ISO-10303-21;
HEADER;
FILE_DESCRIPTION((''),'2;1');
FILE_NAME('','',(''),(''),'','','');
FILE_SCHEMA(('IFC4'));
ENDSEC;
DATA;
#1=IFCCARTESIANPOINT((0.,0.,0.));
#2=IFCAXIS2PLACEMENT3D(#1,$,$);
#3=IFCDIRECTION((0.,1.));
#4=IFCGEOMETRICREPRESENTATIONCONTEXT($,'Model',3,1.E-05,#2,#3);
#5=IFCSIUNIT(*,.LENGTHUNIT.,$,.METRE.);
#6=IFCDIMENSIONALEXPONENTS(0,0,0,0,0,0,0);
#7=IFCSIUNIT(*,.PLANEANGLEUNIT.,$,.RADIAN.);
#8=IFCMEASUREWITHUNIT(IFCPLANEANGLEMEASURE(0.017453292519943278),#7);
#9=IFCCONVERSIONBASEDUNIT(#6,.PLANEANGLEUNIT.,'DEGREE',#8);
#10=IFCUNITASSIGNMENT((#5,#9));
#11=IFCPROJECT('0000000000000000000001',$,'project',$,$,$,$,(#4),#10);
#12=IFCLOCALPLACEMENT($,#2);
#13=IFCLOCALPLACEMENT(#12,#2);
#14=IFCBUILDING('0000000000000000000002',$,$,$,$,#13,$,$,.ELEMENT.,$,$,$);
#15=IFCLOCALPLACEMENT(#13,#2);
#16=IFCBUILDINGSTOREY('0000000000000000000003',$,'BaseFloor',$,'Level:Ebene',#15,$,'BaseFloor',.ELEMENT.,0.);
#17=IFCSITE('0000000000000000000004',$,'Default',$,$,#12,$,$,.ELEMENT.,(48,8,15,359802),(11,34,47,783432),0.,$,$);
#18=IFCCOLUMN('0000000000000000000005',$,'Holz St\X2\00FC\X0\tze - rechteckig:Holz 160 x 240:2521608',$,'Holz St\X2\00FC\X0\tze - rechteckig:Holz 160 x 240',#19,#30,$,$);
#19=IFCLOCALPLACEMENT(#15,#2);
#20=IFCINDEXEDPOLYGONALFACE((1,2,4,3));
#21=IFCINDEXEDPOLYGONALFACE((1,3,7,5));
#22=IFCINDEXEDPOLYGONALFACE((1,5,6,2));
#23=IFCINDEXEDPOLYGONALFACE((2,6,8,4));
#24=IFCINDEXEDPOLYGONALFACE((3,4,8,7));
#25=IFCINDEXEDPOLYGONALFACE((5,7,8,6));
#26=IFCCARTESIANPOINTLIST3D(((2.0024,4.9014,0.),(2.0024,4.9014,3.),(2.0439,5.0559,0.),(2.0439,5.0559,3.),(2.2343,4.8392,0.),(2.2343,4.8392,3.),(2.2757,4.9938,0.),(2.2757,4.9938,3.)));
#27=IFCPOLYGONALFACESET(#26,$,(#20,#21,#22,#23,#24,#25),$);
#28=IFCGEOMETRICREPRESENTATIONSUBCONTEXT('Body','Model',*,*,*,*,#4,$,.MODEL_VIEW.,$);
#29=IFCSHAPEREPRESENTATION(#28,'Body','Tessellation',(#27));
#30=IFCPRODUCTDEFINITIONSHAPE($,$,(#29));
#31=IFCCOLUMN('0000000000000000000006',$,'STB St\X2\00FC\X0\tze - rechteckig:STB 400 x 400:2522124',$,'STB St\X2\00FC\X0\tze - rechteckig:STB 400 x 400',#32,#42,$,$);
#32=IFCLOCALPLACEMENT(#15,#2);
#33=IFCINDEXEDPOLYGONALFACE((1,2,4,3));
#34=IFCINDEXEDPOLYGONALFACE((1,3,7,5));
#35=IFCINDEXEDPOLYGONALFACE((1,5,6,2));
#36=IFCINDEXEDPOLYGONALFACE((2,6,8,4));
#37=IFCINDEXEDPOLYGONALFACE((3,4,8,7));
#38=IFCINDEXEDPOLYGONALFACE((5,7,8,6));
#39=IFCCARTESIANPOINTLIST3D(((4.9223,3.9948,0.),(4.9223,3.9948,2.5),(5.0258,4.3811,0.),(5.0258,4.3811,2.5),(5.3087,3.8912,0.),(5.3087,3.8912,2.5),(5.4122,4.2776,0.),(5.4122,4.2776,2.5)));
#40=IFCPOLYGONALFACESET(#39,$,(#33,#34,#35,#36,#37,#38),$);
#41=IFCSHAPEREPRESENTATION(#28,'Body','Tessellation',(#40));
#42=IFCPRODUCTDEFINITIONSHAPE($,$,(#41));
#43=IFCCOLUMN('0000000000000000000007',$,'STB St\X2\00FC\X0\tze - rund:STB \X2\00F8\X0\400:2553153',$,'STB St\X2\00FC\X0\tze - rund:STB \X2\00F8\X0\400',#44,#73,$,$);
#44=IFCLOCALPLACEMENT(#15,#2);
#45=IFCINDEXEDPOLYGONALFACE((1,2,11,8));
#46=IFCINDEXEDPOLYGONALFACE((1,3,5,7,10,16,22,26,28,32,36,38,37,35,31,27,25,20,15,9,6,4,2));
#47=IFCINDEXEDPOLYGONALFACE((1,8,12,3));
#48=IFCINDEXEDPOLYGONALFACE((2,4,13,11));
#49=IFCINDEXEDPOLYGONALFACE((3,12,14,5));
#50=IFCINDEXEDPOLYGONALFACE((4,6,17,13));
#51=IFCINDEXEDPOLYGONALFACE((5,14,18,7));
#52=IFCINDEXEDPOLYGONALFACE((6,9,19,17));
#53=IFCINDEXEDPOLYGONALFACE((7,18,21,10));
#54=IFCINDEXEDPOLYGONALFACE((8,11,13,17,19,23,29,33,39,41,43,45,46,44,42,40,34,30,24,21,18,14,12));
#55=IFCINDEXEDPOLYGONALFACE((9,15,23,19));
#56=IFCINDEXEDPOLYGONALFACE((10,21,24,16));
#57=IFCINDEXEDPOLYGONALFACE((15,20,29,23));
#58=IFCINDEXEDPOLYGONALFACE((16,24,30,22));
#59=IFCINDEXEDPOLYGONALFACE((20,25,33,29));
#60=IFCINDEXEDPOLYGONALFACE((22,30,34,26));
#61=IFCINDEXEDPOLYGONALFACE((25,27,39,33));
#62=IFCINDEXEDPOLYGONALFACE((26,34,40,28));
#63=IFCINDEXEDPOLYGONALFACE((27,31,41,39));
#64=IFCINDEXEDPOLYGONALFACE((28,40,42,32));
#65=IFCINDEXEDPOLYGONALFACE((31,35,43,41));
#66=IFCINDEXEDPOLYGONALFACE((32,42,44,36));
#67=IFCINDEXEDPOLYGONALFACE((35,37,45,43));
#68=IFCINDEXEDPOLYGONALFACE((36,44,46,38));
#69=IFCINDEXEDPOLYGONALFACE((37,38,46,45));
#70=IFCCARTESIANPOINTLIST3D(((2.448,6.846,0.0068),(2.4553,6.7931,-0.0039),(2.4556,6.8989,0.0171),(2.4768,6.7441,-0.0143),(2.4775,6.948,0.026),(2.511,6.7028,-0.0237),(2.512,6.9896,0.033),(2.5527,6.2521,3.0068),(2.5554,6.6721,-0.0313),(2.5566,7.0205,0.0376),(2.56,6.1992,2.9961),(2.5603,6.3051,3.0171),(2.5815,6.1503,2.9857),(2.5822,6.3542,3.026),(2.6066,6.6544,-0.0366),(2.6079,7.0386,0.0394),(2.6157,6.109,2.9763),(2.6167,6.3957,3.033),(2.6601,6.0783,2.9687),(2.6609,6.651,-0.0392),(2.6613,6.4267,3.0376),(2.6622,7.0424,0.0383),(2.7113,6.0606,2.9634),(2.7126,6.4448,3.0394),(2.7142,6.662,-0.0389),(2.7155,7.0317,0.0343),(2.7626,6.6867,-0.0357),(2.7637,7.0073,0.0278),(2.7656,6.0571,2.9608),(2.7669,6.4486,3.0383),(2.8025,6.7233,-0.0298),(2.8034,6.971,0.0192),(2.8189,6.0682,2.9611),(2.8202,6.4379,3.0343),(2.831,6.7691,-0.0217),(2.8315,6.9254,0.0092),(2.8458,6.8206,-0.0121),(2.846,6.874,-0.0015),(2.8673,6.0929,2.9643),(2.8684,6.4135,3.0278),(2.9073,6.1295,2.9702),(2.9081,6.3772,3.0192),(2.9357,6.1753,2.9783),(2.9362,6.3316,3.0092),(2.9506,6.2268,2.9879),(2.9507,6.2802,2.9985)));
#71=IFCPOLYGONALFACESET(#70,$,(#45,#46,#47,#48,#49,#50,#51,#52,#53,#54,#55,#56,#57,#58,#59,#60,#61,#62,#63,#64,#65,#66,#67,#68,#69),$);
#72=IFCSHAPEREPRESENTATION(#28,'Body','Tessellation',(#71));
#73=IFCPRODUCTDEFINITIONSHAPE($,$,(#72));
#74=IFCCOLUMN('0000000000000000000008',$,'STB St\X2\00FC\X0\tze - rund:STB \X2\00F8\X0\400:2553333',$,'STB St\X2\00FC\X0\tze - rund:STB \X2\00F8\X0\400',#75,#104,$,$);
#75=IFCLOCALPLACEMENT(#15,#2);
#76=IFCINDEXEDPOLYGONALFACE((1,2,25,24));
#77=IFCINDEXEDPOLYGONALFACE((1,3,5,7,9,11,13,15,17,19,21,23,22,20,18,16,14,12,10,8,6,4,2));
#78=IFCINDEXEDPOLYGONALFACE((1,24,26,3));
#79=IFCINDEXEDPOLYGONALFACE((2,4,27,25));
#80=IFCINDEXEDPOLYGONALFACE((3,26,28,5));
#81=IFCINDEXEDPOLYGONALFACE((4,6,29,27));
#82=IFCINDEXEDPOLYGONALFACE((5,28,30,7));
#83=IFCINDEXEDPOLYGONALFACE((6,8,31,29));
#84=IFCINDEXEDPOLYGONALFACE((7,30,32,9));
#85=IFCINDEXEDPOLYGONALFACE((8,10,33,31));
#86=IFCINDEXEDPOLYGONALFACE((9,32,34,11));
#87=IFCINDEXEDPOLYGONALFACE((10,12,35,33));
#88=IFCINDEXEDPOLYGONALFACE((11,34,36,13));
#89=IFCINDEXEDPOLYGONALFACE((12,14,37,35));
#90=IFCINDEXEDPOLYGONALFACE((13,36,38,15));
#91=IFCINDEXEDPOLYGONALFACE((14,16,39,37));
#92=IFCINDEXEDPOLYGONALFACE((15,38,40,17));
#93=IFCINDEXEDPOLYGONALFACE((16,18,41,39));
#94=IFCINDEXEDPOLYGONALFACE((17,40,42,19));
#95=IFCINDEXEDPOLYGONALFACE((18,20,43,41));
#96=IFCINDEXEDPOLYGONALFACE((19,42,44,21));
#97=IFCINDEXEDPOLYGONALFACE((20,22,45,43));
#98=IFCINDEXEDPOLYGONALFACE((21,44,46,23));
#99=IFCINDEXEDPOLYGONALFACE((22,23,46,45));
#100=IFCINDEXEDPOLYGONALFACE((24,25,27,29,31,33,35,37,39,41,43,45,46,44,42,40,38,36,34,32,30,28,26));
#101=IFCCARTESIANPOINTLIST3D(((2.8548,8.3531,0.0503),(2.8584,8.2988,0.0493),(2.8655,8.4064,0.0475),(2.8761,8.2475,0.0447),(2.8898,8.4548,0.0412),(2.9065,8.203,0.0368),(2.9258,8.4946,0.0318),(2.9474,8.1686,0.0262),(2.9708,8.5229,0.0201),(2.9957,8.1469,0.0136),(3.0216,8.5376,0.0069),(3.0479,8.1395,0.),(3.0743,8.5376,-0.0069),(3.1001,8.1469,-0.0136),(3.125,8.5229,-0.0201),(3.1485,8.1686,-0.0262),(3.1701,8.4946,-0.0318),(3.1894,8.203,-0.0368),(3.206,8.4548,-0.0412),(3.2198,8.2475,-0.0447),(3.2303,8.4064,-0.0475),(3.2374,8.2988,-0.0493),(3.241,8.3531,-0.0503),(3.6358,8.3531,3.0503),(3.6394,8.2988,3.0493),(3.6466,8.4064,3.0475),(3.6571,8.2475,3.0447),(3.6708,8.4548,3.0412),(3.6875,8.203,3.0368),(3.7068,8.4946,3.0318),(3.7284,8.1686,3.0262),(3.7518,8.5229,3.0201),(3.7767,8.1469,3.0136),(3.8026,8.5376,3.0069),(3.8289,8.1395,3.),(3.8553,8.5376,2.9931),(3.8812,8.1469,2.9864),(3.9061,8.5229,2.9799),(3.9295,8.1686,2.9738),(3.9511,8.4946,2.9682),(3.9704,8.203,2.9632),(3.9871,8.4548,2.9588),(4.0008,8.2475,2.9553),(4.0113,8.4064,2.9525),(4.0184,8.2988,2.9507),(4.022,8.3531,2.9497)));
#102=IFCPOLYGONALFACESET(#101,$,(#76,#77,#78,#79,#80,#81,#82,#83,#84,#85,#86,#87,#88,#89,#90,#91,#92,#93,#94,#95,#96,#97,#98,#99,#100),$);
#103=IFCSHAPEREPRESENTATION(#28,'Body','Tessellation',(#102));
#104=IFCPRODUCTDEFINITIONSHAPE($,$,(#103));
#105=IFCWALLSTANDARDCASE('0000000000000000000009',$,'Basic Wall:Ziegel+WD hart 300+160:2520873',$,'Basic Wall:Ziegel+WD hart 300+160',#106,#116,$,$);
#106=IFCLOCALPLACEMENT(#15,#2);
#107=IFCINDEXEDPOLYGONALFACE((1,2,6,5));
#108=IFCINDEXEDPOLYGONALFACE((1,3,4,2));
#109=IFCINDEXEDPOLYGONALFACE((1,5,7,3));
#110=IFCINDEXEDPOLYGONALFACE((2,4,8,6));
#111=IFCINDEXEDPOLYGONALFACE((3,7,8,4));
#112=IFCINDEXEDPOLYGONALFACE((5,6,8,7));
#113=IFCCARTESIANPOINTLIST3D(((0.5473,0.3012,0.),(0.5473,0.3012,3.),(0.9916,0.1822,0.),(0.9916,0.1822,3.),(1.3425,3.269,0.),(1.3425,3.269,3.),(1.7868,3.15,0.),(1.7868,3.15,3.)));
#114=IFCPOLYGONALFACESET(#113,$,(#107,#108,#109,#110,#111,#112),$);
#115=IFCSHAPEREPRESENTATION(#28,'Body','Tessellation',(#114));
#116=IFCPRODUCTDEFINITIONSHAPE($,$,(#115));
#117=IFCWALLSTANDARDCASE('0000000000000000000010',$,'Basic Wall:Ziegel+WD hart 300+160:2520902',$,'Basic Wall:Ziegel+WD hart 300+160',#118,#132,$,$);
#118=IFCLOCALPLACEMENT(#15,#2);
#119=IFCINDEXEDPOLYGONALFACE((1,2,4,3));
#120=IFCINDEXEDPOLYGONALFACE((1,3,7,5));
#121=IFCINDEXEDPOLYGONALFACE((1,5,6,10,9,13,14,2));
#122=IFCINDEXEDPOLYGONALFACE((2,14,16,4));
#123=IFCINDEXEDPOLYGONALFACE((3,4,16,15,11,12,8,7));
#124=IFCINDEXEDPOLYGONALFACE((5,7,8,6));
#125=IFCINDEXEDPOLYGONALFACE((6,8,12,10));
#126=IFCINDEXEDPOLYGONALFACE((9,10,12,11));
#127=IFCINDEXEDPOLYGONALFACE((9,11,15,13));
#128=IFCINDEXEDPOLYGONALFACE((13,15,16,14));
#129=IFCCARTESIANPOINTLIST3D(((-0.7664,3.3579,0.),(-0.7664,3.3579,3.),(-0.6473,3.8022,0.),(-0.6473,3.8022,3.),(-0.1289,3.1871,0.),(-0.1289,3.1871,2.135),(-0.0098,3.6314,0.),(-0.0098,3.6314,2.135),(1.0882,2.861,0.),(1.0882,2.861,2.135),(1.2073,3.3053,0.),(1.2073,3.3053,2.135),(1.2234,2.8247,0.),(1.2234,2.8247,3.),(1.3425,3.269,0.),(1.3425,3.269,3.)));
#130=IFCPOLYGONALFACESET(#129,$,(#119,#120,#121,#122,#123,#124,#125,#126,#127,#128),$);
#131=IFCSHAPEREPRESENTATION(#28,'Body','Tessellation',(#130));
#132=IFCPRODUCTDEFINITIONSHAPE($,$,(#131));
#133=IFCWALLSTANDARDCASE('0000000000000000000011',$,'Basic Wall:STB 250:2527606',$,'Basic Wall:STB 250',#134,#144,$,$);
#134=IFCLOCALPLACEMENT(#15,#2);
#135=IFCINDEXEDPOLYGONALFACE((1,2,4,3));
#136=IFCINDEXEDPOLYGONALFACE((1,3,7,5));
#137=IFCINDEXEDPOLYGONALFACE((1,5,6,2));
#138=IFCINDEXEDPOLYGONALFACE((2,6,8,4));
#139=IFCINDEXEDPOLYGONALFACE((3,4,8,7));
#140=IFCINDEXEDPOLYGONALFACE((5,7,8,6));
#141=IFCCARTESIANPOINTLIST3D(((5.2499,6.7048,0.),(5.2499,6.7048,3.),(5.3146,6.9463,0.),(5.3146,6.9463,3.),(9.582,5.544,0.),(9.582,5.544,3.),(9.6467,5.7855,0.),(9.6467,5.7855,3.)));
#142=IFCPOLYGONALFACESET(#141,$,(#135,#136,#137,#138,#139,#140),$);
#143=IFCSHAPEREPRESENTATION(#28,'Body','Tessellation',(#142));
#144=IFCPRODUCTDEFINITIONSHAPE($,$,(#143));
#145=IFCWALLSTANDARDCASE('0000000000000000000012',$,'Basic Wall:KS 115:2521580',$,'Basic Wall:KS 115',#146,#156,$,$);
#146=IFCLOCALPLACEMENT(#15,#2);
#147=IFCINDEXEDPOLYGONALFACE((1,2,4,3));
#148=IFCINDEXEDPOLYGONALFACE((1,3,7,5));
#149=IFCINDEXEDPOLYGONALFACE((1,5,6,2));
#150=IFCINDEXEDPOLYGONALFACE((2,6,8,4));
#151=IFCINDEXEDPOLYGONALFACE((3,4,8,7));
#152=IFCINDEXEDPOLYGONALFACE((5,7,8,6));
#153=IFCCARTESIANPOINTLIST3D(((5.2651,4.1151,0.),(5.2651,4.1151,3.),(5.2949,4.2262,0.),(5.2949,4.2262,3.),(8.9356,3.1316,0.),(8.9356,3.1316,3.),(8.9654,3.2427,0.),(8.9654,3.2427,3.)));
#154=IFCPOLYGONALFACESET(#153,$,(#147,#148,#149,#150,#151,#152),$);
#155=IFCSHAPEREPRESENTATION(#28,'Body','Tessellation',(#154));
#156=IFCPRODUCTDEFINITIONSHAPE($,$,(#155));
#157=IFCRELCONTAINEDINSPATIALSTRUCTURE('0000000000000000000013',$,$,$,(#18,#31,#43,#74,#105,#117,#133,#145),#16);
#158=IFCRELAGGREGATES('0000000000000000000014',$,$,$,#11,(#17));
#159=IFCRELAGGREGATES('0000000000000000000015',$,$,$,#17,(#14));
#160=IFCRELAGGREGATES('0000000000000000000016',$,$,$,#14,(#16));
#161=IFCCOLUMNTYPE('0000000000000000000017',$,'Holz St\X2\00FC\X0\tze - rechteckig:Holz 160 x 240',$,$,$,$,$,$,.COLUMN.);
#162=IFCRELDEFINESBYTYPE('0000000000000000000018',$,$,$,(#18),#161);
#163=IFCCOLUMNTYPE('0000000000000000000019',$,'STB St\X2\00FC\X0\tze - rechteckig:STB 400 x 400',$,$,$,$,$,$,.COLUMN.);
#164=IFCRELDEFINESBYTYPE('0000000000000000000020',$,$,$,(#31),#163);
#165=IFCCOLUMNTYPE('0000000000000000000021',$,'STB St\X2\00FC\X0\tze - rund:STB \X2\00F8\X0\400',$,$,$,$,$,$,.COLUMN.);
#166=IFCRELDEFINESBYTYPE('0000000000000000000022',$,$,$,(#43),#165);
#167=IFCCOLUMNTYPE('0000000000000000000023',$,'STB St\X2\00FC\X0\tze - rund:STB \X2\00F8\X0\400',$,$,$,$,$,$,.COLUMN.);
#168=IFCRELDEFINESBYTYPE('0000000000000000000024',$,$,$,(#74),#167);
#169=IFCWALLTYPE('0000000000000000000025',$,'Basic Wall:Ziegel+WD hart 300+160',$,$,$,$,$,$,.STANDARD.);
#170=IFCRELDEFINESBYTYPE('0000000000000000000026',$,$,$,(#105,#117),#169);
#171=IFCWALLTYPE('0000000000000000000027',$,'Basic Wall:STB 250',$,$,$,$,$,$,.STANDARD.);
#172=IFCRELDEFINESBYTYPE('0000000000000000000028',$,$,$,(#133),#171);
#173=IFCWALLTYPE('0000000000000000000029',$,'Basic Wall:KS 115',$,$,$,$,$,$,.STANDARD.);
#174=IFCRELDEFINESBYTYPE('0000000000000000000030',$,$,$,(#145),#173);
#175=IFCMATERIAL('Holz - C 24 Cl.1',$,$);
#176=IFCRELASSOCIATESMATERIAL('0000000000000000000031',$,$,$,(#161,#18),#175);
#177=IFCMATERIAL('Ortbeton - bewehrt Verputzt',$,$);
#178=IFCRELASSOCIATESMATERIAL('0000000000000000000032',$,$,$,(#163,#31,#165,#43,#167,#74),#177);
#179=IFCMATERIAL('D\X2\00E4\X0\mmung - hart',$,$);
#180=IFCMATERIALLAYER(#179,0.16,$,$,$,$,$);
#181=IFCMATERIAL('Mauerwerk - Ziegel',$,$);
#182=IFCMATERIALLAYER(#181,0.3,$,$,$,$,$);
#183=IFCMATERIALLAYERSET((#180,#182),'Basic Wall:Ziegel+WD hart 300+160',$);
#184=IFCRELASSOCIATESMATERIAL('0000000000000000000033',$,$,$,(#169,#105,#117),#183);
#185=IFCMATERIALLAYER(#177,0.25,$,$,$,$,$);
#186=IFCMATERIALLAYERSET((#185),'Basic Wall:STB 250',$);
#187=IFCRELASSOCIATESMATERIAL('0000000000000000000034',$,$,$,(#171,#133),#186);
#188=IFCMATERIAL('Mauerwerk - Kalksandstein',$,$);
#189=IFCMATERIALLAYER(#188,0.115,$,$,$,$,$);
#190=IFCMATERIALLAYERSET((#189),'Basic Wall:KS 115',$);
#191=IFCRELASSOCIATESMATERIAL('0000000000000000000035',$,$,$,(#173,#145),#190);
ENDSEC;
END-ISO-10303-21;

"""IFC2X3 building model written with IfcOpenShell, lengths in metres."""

from ifc_helpers import new_model, entity, si_unit, converted_unit, direction, frame, frame_2d, origin, origin_2d_with_axis, place, context, subcontext, project, spatial, rectangle, circle, extrude, source, transform, mapped, material, layer, layer_set, layer_usage, type_object, type_shapes, element, save


model = new_model("IFC2X3")

# Units and contexts
model_context = context("Model", 3, precision=1e-05, world=origin(), true_north=direction((0.0, 1.0)))
body_context = subcontext(model_context, "Body", "Model", "MODEL_VIEW")
ifc_project = project(units=[si_unit("LENGTHUNIT", "METRE"), converted_unit("PLANEANGLEUNIT", "DEGREE", entity("IfcPlaneAngleMeasure", 0.017453292519943278), si_unit("PLANEANGLEUNIT", "RADIAN"), dimensions=[0, 0, 0, 0, 0, 0, 0])], contexts=[model_context])

# Site, building, storey
site_placement = place(None, origin())
site = spatial("IfcSite", under=ifc_project, at=site_placement, Name="Default", CompositionType="ELEMENT", RefLatitude=(48, 8, 15, 359802), RefLongitude=(11, 34, 47, 783432), RefElevation=0.0)
building_placement = place(site_placement, origin())
building = spatial("IfcBuilding", under=site, at=building_placement, CompositionType="ELEMENT")
storey_placement = place(building_placement, origin())
storey = spatial("IfcBuildingStorey", under=building, at=storey_placement, Name="BaseFloor", ObjectType="Level:Ebene", LongName="BaseFloor", CompositionType="ELEMENT", Elevation=0.0)

# Columns
ifc_material_1 = material(Name="Holz - C 24 Cl.1")
column_type_1 = type_object("IfcColumnType", Name="Holz Stütze - rechteckig:Holz 160 x 240", PredefinedType="COLUMN", material=ifc_material_1)
shared_shape_1 = source(origin(), body_context, "Body", "SweptSolid", [
    extrude(rectangle(XDim=0.16, YDim=0.24, at=frame_2d((0.0, 0.0), x_axis=(1.0, 0.0))), frame((2.1391, 4.9476, 0.0), z_axis=(0.0, 0.0, 1.0), x_axis=(-0.258819, -0.965926, 0.0)), (0.0, 0.0, 1.0), 3.0),
])
type_shapes(column_type_1, [shared_shape_1])
column_1_placement = place(storey_placement, origin())
element("IfcColumn", 1, at=column_1_placement, inside=storey, type_object=column_type_1, material=ifc_material_1, Name="Holz Stütze - rechteckig:Holz 160 x 240:2521608", ObjectType="Holz Stütze - rechteckig:Holz 160 x 240", context=body_context, shape_type="MappedRepresentation", body=[
    mapped(shared_shape_1, transform((0.0, 0.0, 0.0), scale=1.0)),
])
ifc_material_2 = material(Name="Ortbeton - bewehrt Verputzt")
column_type_2 = type_object("IfcColumnType", Name="STB Stütze - rechteckig:STB 400 x 400", PredefinedType="COLUMN", material=ifc_material_2)
shared_shape_2 = source(origin(), body_context, "Body", "SweptSolid", [
    extrude(rectangle(XDim=0.4, YDim=0.4, at=origin_2d_with_axis()), frame((0.0, 0.0, 0.0), z_axis=(0.0, 0.0, 1.0), x_axis=(-1.0, 0.0, 0.0)), (0.0, 0.0, 1.0), 2.5),
])
type_shapes(column_type_2, [shared_shape_2])
column_2_placement = place(storey_placement, frame((5.1672, 4.1362, 0.0), z_axis=(0.0, 0.0, 1.0), x_axis=(0.258819, 0.965926, 0.0)))
element("IfcColumn", 2, at=column_2_placement, inside=storey, type_object=column_type_2, material=ifc_material_2, Name="STB Stütze - rechteckig:STB 400 x 400:2522124", ObjectType="STB Stütze - rechteckig:STB 400 x 400", context=body_context, shape_type="MappedRepresentation", body=[
    mapped(shared_shape_2, transform((0.0, 0.0, 0.0), scale=1.0)),
])
column_type_3 = type_object("IfcColumnType", Name="STB Stütze - rund:STB ø400", PredefinedType="COLUMN", material=ifc_material_2)
shared_shape_3 = source(origin(), body_context, "Body", "SweptSolid", [
    extrude(circle(Radius=0.2, at=frame_2d((0.0, 0.0), x_axis=(1.0, 0.0))), frame((2.6479, 6.8466, 0.0), z_axis=(0.034218, -0.194063, 0.980392), x_axis=(-0.999409, -0.003353, 0.034218)), (0.0, 0.0, 1.0), 3.06),
])
type_shapes(column_type_3, [shared_shape_3])
column_3_placement = place(storey_placement, origin())
element("IfcColumn", 3, at=column_3_placement, inside=storey, type_object=column_type_3, material=ifc_material_2, Name="STB Stütze - rund:STB ø400:2553153", ObjectType="STB Stütze - rund:STB ø400", context=body_context, shape_type="MappedRepresentation", body=[
    mapped(shared_shape_3, transform((0.0, 0.0, 0.0), scale=1.0)),
])
column_type_4 = type_object("IfcColumnType", Name="STB Stütze - rund:STB ø400", PredefinedType="COLUMN", material=ifc_material_2)
shared_shape_4 = source(origin(), body_context, "Body", "SweptSolid", [
    extrude(circle(Radius=0.2, at=frame_2d((0.0, 0.0), x_axis=(1.0, 0.0))), frame((3.0479, 8.3395, 0.0), z_axis=(0.251944, 0.0, 0.967742), x_axis=(0.0, -1.0, 0.0)), (0.0, 0.0, 1.0), 3.1),
])
type_shapes(column_type_4, [shared_shape_4])
column_4_placement = place(storey_placement, origin())
element("IfcColumn", 4, at=column_4_placement, inside=storey, type_object=column_type_4, material=ifc_material_2, Name="STB Stütze - rund:STB ø400:2553333", ObjectType="STB Stütze - rund:STB ø400", context=body_context, shape_type="MappedRepresentation", body=[
    mapped(shared_shape_4, transform((0.0, 0.0, 0.0), scale=1.0)),
])

# Wall
ifc_material_3 = material(Name="Dämmung - hart")
ifc_layer_1 = layer(ifc_material_3, 0.16)
ifc_material_4 = material(Name="Mauerwerk - Ziegel")
ifc_layer_2 = layer(ifc_material_4, 0.3)
ifc_layer_set_1 = layer_set([ifc_layer_1, ifc_layer_2], Name="Basic Wall:Ziegel+WD hart 300+160")
ifc_layer_usage_1 = layer_usage(ifc_layer_set_1, "AXIS2", "NEGATIVE", 0.23)
wall_type_1 = type_object("IfcWallType", Name="Basic Wall:Ziegel+WD hart 300+160", PredefinedType="STANDARD", material=ifc_layer_set_1)
wall_1_placement = place(storey_placement, frame((0.7694, 0.2417, 0.0), z_axis=(0.0, 0.0, 1.0), x_axis=(0.258819, 0.965926, 0.0)))
element("IfcWallStandardCase", 5, at=wall_1_placement, inside=storey, type_object=wall_type_1, material=ifc_layer_usage_1, Name="Basic Wall:Ziegel+WD hart 300+160:2520873", ObjectType="Basic Wall:Ziegel+WD hart 300+160", context=body_context, shape_type="SweptSolid", body=[
    extrude(rectangle(XDim=3.0725, YDim=0.46, at=frame_2d((1.5363, 0.0), x_axis=(-1.0, 0.0))), origin(), (0.0, 0.0, 1.0), 3.0),
])

# Wall, opening
ifc_layer_usage_2 = layer_usage(ifc_layer_set_1, "AXIS2", "NEGATIVE", 0.23)
wall_2_placement = place(storey_placement, frame((1.283, 3.0469, 0.0), z_axis=(0.0, 0.0, 1.0), x_axis=(-0.965926, 0.258819, 0.0)))
wall_2 = element("IfcWallStandardCase", 6, at=wall_2_placement, inside=storey, type_object=wall_type_1, material=ifc_layer_usage_2, Name="Basic Wall:Ziegel+WD hart 300+160:2520902", ObjectType="Basic Wall:Ziegel+WD hart 300+160", context=body_context, shape_type="SweptSolid", body=[
    extrude(rectangle(XDim=2.06, YDim=0.46, at=frame_2d((1.03, 0.0), x_axis=(1.0, 0.0))), origin(), (0.0, 0.0, 1.0), 3.0),
])
opening_1_placement = place(wall_2_placement, frame((1.4, 0.23, -0.18)))
element("IfcOpeningElement", 7, at=opening_1_placement, cuts=wall_2, ObjectType="Opening", context=body_context, shape_type="SweptSolid", body=[
    extrude(rectangle(XDim=2.315, YDim=1.26, at=frame_2d((1.1575, 0.63), x_axis=(-1.0, 0.0))), frame((0.0, 0.0, 0.0), z_axis=(0.0, -1.0, 0.0), x_axis=(0.0, 0.0, 1.0)), (0.0, 0.0, 1.0), 0.46),
])
ifc_layer_3 = layer(ifc_material_2, 0.25)
ifc_layer_set_2 = layer_set([ifc_layer_3], Name="Basic Wall:STB 250")
wall_type_2 = type_object("IfcWallType", Name="Basic Wall:STB 250", PredefinedType="STANDARD", material=ifc_layer_set_2)

# Walls
ifc_layer_usage_3 = layer_usage(ifc_layer_set_2, "AXIS2", "NEGATIVE", 0.125)
wall_3_placement = place(storey_placement, frame((5.2822, 6.8256, 0.0), z_axis=(0.0, 0.0, 1.0), x_axis=(0.965926, -0.258819, 0.0)))
element("IfcWallStandardCase", 8, at=wall_3_placement, inside=storey, type_object=wall_type_2, material=ifc_layer_usage_3, Name="Basic Wall:STB 250:2527606", ObjectType="Basic Wall:STB 250", context=body_context, shape_type="SweptSolid", body=[
    extrude(rectangle(XDim=4.485, YDim=0.25, at=frame_2d((2.2425, 0.0), x_axis=(-1.0, 0.0))), origin(), (0.0, 0.0, 1.0), 3.0),
])
ifc_material_5 = material(Name="Mauerwerk - Kalksandstein")
ifc_layer_4 = layer(ifc_material_5, 0.115)
ifc_layer_set_3 = layer_set([ifc_layer_4], Name="Basic Wall:KS 115")
ifc_layer_usage_4 = layer_usage(ifc_layer_set_3, "AXIS2", "NEGATIVE", 0.0575)
wall_type_3 = type_object("IfcWallType", Name="Basic Wall:KS 115", PredefinedType="STANDARD", material=ifc_layer_set_3)
wall_4_placement = place(storey_placement, frame((8.9505, 3.1871, 0.0), z_axis=(0.0, 0.0, 1.0), x_axis=(-0.965926, 0.258819, 0.0)))
element("IfcWallStandardCase", 9, at=wall_4_placement, inside=storey, type_object=wall_type_3, material=ifc_layer_usage_4, Name="Basic Wall:KS 115:2521580", ObjectType="Basic Wall:KS 115", context=body_context, shape_type="SweptSolid", body=[
    extrude(rectangle(XDim=3.8, YDim=0.115, at=frame_2d((1.9, 0.0), x_axis=(-1.0, 0.0))), origin(), (0.0, 0.0, 1.0), 3.0),
])

save(model, "model.ifc")
